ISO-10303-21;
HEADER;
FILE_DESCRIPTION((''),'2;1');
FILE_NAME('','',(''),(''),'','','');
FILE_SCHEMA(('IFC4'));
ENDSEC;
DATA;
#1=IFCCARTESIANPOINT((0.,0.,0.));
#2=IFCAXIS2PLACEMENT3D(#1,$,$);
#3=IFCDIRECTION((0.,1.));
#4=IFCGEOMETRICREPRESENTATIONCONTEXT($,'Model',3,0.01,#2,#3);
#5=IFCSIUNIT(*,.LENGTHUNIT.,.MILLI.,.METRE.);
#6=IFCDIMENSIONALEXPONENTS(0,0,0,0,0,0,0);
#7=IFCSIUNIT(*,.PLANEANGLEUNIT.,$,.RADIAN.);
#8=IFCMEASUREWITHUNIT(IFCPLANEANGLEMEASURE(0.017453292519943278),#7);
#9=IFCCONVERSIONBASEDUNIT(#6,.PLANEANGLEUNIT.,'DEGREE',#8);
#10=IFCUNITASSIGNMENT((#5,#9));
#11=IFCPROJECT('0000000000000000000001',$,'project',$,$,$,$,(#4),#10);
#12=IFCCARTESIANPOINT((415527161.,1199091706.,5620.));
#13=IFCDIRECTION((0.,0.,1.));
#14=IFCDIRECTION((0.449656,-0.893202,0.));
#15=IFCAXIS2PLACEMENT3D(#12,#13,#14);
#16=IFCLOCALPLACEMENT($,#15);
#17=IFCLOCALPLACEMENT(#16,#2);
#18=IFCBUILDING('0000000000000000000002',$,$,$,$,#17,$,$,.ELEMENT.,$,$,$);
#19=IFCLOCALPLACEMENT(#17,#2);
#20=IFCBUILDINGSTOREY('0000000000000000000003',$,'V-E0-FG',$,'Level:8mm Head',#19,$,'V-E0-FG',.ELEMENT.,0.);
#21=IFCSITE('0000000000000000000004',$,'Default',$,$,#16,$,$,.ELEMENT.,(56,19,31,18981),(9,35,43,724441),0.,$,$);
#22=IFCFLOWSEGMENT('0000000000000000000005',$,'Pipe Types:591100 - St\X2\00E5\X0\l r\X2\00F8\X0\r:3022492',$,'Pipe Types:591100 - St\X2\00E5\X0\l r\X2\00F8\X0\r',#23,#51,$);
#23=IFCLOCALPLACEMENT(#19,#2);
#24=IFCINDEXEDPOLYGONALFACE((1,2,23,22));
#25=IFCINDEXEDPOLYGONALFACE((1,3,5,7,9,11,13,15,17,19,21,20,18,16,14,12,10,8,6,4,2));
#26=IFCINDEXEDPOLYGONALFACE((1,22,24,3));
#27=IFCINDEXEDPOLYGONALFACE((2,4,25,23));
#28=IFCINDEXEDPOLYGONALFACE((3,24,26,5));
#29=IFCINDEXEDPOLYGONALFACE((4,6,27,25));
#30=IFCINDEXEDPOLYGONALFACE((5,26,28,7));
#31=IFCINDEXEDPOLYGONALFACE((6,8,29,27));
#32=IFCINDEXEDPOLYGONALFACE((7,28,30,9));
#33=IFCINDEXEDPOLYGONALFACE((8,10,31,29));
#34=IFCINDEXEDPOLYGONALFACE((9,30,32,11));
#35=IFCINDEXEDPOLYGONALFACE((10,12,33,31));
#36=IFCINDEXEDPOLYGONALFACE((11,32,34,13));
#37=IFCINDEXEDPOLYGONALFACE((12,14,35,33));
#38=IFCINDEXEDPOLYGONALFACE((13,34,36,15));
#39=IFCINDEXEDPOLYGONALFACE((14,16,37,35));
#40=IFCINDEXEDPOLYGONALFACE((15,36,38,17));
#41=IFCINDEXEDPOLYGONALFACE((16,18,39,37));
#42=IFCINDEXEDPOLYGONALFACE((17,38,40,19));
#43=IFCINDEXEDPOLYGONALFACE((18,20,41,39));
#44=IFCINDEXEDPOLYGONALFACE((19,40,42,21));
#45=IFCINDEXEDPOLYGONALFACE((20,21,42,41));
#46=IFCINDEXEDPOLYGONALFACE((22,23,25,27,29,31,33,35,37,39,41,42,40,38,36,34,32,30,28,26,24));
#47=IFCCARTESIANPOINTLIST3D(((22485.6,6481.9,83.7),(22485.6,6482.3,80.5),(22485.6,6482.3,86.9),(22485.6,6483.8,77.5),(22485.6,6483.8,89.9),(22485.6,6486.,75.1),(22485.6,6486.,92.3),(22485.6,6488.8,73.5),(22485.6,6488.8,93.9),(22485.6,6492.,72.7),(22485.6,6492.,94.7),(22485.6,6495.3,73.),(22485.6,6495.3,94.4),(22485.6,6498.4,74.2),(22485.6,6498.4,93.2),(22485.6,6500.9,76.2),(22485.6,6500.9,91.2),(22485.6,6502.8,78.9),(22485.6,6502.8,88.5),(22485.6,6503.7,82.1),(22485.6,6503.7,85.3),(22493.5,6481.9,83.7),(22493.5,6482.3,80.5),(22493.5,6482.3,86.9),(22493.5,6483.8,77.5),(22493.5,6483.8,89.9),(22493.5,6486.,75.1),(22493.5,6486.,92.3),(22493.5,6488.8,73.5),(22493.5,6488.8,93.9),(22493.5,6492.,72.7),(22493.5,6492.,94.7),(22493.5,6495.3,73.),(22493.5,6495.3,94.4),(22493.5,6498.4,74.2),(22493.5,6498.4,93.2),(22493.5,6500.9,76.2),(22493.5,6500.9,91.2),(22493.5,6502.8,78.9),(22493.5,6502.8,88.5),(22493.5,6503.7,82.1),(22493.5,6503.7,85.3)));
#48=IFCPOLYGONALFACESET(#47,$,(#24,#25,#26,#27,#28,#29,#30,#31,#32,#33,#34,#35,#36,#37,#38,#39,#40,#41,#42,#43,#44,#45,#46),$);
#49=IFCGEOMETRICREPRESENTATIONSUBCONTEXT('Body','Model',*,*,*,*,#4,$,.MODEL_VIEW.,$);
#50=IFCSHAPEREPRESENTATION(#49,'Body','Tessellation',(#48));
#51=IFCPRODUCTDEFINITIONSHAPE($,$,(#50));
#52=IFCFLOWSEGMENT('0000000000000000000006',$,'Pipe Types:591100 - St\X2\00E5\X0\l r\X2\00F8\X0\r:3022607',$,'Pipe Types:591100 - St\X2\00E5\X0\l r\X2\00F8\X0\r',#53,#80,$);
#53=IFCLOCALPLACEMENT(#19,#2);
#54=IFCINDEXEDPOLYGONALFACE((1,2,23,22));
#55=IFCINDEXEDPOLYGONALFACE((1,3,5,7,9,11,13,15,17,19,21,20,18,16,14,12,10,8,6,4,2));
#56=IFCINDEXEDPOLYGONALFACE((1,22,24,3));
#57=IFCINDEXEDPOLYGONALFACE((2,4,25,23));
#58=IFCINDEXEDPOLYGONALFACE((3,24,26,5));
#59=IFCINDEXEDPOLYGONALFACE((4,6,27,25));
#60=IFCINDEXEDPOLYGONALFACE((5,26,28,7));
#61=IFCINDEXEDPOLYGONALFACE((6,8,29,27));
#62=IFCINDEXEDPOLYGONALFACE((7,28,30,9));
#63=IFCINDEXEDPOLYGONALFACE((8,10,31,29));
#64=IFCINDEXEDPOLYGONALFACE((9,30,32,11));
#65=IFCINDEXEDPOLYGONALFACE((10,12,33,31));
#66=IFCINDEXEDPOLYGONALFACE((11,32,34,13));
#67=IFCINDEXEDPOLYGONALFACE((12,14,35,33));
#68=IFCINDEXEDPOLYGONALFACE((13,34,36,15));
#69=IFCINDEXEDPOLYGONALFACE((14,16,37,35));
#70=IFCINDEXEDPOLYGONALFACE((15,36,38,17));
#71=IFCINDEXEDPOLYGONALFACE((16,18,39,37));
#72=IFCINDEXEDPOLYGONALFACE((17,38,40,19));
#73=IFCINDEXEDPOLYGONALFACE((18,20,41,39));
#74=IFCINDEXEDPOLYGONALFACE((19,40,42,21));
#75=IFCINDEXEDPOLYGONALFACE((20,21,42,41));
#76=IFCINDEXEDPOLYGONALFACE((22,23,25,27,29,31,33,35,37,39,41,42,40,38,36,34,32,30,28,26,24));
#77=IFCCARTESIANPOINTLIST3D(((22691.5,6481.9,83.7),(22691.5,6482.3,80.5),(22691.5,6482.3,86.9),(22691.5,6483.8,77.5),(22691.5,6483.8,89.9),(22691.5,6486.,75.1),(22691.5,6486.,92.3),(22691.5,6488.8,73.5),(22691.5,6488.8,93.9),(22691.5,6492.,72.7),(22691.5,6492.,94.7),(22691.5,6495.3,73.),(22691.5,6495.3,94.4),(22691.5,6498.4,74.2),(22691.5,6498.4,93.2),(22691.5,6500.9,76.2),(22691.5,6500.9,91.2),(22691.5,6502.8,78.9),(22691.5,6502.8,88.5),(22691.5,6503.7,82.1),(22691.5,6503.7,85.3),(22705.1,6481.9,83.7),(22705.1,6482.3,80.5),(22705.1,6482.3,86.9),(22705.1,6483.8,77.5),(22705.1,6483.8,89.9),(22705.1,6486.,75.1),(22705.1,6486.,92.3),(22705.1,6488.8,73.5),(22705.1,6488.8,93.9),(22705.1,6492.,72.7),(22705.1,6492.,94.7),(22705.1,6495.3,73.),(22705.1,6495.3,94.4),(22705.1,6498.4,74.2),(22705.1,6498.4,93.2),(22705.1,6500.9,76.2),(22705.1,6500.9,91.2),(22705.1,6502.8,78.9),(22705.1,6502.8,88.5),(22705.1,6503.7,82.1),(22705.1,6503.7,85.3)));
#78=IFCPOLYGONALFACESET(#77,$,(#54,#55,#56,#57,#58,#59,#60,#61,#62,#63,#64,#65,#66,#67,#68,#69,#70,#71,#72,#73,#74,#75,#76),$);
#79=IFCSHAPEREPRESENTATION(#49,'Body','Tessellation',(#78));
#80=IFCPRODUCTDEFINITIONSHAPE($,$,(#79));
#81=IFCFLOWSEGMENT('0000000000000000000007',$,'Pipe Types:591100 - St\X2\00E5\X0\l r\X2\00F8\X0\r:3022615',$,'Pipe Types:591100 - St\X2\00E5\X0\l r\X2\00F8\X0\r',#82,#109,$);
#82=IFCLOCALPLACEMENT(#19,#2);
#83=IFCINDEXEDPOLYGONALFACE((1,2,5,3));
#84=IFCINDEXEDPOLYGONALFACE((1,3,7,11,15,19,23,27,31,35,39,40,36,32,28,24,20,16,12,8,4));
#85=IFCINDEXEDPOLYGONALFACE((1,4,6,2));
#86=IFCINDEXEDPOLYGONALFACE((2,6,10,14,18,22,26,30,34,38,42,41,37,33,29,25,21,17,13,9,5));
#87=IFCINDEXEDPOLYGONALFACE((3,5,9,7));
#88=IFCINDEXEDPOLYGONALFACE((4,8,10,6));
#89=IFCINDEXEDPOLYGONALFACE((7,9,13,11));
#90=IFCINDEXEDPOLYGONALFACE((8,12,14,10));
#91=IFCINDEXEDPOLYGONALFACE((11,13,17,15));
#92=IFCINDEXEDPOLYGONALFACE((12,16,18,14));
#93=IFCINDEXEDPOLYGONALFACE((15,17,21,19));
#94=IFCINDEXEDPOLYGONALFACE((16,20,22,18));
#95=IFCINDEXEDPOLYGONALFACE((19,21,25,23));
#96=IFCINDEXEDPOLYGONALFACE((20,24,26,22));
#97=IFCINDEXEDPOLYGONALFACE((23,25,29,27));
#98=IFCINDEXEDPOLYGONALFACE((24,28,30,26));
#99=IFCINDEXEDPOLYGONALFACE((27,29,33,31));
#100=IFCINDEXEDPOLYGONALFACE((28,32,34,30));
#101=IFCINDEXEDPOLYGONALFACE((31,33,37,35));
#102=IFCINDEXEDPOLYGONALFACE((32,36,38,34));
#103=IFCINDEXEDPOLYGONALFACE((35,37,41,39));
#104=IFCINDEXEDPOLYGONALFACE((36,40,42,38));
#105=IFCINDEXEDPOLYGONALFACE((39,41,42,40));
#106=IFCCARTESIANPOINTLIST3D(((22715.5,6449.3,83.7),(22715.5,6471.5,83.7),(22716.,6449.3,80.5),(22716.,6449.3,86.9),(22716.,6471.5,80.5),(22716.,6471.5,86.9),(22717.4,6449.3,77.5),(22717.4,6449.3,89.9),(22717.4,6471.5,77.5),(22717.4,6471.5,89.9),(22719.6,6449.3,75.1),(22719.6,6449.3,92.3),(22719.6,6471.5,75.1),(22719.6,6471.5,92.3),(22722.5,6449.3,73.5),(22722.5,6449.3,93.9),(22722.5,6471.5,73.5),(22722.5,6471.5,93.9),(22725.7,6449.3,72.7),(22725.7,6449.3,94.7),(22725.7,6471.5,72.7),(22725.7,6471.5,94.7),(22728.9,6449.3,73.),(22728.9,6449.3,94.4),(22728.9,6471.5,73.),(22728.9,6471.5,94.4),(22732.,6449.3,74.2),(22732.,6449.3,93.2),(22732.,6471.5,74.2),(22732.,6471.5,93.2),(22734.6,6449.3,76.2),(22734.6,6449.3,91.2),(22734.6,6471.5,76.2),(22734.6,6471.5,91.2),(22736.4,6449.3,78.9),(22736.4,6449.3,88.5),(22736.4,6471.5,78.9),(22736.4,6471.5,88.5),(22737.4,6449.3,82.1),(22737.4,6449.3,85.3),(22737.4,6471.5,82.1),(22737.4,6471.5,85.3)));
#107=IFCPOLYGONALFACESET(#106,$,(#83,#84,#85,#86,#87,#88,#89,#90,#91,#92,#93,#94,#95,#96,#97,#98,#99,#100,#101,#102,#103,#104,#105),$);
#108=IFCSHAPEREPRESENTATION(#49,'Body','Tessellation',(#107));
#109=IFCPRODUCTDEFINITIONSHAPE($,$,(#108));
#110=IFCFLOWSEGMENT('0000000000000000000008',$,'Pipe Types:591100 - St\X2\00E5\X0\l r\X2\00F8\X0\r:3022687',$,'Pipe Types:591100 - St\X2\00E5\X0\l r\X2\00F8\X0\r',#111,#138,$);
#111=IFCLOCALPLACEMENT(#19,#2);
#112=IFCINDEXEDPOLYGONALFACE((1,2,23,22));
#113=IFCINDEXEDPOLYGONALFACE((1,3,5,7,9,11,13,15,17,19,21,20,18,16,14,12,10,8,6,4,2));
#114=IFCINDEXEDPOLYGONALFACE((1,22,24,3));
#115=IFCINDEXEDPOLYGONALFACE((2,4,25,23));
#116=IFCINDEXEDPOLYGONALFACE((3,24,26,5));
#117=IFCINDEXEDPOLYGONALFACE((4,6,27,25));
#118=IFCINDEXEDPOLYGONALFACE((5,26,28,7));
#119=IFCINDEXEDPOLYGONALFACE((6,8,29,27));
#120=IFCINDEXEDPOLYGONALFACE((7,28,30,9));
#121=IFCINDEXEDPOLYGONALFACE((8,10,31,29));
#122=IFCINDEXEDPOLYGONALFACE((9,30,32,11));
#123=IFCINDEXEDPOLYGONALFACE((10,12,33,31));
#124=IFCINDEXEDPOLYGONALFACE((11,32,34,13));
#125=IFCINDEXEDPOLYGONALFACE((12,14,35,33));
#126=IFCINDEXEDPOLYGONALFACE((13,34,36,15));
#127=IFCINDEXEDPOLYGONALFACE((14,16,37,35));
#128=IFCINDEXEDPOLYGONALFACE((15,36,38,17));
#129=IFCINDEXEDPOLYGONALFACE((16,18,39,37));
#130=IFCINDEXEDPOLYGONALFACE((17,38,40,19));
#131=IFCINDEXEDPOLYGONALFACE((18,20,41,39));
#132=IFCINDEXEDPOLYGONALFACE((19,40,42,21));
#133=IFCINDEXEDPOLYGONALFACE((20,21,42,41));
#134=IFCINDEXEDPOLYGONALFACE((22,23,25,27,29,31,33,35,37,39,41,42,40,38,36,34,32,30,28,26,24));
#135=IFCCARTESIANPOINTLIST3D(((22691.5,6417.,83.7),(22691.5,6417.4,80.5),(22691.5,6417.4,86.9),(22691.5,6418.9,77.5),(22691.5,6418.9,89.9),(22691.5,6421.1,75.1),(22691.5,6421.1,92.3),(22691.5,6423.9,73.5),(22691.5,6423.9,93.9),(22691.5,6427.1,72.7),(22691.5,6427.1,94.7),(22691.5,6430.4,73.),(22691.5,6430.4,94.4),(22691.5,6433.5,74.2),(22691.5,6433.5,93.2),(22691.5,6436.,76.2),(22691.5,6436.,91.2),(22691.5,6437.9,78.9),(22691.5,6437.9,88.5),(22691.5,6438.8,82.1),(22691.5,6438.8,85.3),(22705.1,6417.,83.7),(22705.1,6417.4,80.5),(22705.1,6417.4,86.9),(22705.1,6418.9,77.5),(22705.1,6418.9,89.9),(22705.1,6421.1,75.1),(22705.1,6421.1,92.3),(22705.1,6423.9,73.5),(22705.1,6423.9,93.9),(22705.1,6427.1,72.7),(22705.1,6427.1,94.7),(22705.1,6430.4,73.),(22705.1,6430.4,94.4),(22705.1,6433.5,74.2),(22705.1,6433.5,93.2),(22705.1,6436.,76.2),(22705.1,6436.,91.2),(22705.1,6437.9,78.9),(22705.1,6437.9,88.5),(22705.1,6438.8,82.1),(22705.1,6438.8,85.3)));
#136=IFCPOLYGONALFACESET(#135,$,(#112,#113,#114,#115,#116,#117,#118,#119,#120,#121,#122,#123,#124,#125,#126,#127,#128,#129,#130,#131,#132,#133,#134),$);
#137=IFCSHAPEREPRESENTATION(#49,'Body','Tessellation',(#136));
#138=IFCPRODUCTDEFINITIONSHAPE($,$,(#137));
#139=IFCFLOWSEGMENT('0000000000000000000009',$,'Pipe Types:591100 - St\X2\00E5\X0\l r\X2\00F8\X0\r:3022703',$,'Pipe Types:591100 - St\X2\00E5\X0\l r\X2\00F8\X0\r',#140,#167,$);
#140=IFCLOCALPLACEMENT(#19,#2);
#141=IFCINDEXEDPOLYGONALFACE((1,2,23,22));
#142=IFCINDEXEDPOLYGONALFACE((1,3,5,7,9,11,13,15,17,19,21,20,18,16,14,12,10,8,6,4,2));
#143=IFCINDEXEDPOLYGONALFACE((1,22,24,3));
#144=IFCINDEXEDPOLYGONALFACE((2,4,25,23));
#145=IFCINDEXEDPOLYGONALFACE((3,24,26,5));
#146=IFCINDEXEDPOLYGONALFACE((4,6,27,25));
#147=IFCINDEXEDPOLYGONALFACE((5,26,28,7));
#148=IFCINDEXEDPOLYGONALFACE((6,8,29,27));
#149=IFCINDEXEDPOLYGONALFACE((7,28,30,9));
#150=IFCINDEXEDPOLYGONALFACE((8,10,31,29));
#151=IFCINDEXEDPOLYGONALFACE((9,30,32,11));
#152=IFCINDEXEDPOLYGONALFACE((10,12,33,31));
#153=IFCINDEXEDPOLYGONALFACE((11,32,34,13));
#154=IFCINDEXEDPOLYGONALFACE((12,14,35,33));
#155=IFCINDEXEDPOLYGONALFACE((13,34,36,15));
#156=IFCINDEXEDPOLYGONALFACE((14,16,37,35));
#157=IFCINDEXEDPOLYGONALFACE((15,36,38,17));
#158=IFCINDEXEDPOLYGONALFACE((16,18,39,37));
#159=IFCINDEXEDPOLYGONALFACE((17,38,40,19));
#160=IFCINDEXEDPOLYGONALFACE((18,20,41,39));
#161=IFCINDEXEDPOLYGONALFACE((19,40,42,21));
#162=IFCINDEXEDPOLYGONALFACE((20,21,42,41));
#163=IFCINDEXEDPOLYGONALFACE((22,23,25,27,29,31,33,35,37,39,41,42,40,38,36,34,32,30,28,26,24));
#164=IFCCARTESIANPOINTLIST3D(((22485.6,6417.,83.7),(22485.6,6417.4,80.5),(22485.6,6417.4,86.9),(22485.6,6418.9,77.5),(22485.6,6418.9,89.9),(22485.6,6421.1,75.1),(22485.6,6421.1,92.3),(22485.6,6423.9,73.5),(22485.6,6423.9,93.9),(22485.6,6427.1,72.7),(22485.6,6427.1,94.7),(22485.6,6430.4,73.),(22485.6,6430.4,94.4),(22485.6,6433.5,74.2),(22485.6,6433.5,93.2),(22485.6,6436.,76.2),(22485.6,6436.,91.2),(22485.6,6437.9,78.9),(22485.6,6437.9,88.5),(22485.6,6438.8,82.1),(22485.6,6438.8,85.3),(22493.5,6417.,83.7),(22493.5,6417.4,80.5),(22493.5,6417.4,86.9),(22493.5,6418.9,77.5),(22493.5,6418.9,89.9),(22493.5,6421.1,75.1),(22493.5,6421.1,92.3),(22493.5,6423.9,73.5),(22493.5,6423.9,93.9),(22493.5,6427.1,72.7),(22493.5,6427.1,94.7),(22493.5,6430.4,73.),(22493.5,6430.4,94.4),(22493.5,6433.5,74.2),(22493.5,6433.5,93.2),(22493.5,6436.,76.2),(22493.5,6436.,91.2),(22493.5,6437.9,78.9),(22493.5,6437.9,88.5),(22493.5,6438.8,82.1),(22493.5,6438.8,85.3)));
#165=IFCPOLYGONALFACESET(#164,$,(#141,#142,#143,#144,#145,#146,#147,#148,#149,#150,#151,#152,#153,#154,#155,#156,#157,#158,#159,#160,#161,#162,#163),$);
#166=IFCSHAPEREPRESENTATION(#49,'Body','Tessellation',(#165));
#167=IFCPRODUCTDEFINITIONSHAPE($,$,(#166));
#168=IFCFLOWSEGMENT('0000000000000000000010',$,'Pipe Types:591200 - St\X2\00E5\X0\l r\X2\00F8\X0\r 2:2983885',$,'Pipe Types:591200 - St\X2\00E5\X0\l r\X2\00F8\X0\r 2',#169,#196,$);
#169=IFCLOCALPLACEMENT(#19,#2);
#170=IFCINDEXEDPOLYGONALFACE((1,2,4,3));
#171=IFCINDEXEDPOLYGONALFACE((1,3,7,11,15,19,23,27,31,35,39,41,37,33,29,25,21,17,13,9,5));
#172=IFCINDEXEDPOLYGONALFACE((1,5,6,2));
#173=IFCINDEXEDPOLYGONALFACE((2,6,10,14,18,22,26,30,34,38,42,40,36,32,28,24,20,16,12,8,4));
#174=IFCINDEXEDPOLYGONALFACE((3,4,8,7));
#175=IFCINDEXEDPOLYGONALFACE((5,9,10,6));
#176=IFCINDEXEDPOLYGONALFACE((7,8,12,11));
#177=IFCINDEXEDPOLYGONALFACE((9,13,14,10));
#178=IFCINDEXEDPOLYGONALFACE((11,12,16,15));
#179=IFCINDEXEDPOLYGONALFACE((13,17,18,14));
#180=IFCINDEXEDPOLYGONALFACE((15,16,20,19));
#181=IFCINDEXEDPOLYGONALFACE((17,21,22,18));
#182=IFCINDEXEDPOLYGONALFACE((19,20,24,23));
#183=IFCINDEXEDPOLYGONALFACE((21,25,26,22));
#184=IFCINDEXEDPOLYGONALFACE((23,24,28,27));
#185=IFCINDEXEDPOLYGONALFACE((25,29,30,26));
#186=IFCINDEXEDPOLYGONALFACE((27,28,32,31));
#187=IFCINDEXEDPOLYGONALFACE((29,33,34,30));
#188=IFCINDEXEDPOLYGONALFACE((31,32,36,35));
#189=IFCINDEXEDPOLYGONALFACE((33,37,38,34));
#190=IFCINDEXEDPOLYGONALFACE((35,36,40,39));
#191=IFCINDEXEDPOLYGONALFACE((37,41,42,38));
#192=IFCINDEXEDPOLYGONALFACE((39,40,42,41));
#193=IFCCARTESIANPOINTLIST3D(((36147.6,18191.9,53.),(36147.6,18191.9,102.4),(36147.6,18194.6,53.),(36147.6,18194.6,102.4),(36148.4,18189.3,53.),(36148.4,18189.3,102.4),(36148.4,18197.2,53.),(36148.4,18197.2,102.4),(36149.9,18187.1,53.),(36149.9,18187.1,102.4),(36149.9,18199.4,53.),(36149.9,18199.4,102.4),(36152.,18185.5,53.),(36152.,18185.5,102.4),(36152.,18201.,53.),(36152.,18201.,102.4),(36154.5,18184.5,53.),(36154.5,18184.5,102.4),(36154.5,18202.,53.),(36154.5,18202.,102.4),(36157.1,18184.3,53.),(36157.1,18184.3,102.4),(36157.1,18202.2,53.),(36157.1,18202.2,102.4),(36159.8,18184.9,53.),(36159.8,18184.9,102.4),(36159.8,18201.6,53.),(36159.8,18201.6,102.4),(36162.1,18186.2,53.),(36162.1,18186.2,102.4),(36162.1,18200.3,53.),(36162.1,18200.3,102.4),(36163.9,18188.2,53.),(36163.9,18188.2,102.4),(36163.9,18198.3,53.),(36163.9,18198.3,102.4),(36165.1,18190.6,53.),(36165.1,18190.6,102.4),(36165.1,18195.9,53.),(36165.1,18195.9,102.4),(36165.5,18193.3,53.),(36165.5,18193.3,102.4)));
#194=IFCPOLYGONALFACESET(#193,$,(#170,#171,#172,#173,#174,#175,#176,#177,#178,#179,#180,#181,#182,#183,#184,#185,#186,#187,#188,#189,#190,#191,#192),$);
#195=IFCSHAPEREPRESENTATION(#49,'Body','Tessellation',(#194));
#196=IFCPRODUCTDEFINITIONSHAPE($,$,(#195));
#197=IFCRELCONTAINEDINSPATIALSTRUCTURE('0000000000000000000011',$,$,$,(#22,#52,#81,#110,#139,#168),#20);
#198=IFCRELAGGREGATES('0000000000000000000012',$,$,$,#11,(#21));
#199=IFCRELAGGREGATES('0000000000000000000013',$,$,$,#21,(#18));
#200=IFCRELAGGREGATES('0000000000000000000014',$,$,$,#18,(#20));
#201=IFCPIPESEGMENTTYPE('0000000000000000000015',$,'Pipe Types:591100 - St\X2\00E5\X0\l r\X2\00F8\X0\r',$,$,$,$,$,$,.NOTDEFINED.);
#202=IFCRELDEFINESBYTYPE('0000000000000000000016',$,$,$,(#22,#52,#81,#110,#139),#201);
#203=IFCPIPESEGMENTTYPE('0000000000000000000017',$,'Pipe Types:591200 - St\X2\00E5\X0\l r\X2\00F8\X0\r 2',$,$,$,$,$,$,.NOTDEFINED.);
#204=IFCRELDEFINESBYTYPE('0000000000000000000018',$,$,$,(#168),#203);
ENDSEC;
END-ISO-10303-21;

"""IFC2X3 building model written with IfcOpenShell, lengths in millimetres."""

from ifc_helpers import new_model, entity, si_unit, converted_unit, direction, frame, frame_2d, origin, origin_2d_with_axis, place, context, subcontext, project, spatial, circle, extrude, type_object, element, save


model = new_model("IFC2X3")

# Units and contexts
model_context = context("Model", 3, precision=0.01, world=origin(), true_north=direction((0.0, 1.0)))
body_context = subcontext(model_context, "Body", "Model", "MODEL_VIEW")
ifc_project = project(units=[si_unit("LENGTHUNIT", "METRE", prefix="MILLI"), converted_unit("PLANEANGLEUNIT", "DEGREE", entity("IfcPlaneAngleMeasure", 0.017453292519943278), si_unit("PLANEANGLEUNIT", "RADIAN"), dimensions=[0, 0, 0, 0, 0, 0, 0])], contexts=[model_context])

# Site, building, storey
site_placement = place(None, frame((415527161.0, 1199091706.0, 5620.0), z_axis=(0.0, 0.0, 1.0), x_axis=(0.449656, -0.893202, 0.0)))
site = spatial("IfcSite", under=ifc_project, at=site_placement, Name="Default", CompositionType="ELEMENT", RefLatitude=(56, 19, 31, 18981), RefLongitude=(9, 35, 43, 724441), RefElevation=0.0)
building_placement = place(site_placement, origin())
building = spatial("IfcBuilding", under=site, at=building_placement, CompositionType="ELEMENT")
storey_placement = place(building_placement, origin())
storey = spatial("IfcBuildingStorey", under=building, at=storey_placement, Name="V-E0-FG", ObjectType="Level:8mm Head", LongName="V-E0-FG", CompositionType="ELEMENT", Elevation=0.0)

# Flow segments
pipe_segment_type_1 = type_object("IfcPipeSegmentType", Name="Pipe Types:591100 - Stål rør", PredefinedType="NOTDEFINED")
flow_segment_1_placement = place(storey_placement, origin())
element("IfcFlowSegment", 1, at=flow_segment_1_placement, inside=storey, type_object=pipe_segment_type_1, Name="Pipe Types:591100 - Stål rør:3022492", ObjectType="Pipe Types:591100 - Stål rør", context=body_context, shape_type="SweptSolid", body=[
    extrude(circle(Radius=11.0, at=origin_2d_with_axis()), frame((22485.6, 6492.9, 83.7), z_axis=(1.0, -0.000144, 0.0), x_axis=(-0.000144, -1.0, 0.0)), (0.0, 0.0, 1.0), 7.9),
])
flow_segment_2_placement = place(storey_placement, origin())
element("IfcFlowSegment", 2, at=flow_segment_2_placement, inside=storey, type_object=pipe_segment_type_1, Name="Pipe Types:591100 - Stål rør:3022607", ObjectType="Pipe Types:591100 - Stål rør", context=body_context, shape_type="SweptSolid", body=[
    extrude(circle(Radius=11.0, at=origin_2d_with_axis()), frame((22691.5, 6492.9, 83.7), z_axis=(1.0, 0.0, 0.0), x_axis=(0.0, -1.0, 0.0)), (0.0, 0.0, 1.0), 13.7),
])
flow_segment_3_placement = place(storey_placement, origin())
element("IfcFlowSegment", 3, at=flow_segment_3_placement, inside=storey, type_object=pipe_segment_type_1, Name="Pipe Types:591100 - Stål rør:3022615", ObjectType="Pipe Types:591100 - Stål rør", context=body_context, shape_type="SweptSolid", body=[
    extrude(circle(Radius=11.0, at=frame_2d((0.0, 0.0), x_axis=(1.0, 0.0))), frame((22726.5, 6449.3, 83.7), z_axis=(0.0, 1.0, 0.0), x_axis=(-1.0, 0.0, 0.0)), (0.0, 0.0, 1.0), 22.2),
])
flow_segment_4_placement = place(storey_placement, origin())
element("IfcFlowSegment", 4, at=flow_segment_4_placement, inside=storey, type_object=pipe_segment_type_1, Name="Pipe Types:591100 - Stål rør:3022687", ObjectType="Pipe Types:591100 - Stål rør", context=body_context, shape_type="SweptSolid", body=[
    extrude(circle(Radius=11.0, at=origin_2d_with_axis()), frame((22691.5, 6428.0, 83.7), z_axis=(1.0, 0.0, 0.0), x_axis=(0.0, -1.0, 0.0)), (0.0, 0.0, 1.0), 13.7),
])
flow_segment_5_placement = place(storey_placement, origin())
element("IfcFlowSegment", 5, at=flow_segment_5_placement, inside=storey, type_object=pipe_segment_type_1, Name="Pipe Types:591100 - Stål rør:3022703", ObjectType="Pipe Types:591100 - Stål rør", context=body_context, shape_type="SweptSolid", body=[
    extrude(circle(Radius=11.0, at=origin_2d_with_axis()), frame((22485.6, 6428.0, 83.7), z_axis=(1.0, 0.0, 0.0), x_axis=(0.0, -1.0, 0.0)), (0.0, 0.0, 1.0), 7.9),
])
pipe_segment_type_2 = type_object("IfcPipeSegmentType", Name="Pipe Types:591200 - Stål rør 2", PredefinedType="NOTDEFINED")
flow_segment_6_placement = place(storey_placement, origin())
element("IfcFlowSegment", 6, at=flow_segment_6_placement, inside=storey, type_object=pipe_segment_type_2, Name="Pipe Types:591200 - Stål rør 2:2983885", ObjectType="Pipe Types:591200 - Stål rør 2", context=body_context, shape_type="SweptSolid", body=[
    extrude(circle(Radius=9.0, at=frame_2d((0.0, 0.0), x_axis=(1.0, 0.0))), frame((36156.5, 18193.3, 53.0)), (0.0, 0.0, 1.0), 49.4),
])

save(model, "model.ifc")
